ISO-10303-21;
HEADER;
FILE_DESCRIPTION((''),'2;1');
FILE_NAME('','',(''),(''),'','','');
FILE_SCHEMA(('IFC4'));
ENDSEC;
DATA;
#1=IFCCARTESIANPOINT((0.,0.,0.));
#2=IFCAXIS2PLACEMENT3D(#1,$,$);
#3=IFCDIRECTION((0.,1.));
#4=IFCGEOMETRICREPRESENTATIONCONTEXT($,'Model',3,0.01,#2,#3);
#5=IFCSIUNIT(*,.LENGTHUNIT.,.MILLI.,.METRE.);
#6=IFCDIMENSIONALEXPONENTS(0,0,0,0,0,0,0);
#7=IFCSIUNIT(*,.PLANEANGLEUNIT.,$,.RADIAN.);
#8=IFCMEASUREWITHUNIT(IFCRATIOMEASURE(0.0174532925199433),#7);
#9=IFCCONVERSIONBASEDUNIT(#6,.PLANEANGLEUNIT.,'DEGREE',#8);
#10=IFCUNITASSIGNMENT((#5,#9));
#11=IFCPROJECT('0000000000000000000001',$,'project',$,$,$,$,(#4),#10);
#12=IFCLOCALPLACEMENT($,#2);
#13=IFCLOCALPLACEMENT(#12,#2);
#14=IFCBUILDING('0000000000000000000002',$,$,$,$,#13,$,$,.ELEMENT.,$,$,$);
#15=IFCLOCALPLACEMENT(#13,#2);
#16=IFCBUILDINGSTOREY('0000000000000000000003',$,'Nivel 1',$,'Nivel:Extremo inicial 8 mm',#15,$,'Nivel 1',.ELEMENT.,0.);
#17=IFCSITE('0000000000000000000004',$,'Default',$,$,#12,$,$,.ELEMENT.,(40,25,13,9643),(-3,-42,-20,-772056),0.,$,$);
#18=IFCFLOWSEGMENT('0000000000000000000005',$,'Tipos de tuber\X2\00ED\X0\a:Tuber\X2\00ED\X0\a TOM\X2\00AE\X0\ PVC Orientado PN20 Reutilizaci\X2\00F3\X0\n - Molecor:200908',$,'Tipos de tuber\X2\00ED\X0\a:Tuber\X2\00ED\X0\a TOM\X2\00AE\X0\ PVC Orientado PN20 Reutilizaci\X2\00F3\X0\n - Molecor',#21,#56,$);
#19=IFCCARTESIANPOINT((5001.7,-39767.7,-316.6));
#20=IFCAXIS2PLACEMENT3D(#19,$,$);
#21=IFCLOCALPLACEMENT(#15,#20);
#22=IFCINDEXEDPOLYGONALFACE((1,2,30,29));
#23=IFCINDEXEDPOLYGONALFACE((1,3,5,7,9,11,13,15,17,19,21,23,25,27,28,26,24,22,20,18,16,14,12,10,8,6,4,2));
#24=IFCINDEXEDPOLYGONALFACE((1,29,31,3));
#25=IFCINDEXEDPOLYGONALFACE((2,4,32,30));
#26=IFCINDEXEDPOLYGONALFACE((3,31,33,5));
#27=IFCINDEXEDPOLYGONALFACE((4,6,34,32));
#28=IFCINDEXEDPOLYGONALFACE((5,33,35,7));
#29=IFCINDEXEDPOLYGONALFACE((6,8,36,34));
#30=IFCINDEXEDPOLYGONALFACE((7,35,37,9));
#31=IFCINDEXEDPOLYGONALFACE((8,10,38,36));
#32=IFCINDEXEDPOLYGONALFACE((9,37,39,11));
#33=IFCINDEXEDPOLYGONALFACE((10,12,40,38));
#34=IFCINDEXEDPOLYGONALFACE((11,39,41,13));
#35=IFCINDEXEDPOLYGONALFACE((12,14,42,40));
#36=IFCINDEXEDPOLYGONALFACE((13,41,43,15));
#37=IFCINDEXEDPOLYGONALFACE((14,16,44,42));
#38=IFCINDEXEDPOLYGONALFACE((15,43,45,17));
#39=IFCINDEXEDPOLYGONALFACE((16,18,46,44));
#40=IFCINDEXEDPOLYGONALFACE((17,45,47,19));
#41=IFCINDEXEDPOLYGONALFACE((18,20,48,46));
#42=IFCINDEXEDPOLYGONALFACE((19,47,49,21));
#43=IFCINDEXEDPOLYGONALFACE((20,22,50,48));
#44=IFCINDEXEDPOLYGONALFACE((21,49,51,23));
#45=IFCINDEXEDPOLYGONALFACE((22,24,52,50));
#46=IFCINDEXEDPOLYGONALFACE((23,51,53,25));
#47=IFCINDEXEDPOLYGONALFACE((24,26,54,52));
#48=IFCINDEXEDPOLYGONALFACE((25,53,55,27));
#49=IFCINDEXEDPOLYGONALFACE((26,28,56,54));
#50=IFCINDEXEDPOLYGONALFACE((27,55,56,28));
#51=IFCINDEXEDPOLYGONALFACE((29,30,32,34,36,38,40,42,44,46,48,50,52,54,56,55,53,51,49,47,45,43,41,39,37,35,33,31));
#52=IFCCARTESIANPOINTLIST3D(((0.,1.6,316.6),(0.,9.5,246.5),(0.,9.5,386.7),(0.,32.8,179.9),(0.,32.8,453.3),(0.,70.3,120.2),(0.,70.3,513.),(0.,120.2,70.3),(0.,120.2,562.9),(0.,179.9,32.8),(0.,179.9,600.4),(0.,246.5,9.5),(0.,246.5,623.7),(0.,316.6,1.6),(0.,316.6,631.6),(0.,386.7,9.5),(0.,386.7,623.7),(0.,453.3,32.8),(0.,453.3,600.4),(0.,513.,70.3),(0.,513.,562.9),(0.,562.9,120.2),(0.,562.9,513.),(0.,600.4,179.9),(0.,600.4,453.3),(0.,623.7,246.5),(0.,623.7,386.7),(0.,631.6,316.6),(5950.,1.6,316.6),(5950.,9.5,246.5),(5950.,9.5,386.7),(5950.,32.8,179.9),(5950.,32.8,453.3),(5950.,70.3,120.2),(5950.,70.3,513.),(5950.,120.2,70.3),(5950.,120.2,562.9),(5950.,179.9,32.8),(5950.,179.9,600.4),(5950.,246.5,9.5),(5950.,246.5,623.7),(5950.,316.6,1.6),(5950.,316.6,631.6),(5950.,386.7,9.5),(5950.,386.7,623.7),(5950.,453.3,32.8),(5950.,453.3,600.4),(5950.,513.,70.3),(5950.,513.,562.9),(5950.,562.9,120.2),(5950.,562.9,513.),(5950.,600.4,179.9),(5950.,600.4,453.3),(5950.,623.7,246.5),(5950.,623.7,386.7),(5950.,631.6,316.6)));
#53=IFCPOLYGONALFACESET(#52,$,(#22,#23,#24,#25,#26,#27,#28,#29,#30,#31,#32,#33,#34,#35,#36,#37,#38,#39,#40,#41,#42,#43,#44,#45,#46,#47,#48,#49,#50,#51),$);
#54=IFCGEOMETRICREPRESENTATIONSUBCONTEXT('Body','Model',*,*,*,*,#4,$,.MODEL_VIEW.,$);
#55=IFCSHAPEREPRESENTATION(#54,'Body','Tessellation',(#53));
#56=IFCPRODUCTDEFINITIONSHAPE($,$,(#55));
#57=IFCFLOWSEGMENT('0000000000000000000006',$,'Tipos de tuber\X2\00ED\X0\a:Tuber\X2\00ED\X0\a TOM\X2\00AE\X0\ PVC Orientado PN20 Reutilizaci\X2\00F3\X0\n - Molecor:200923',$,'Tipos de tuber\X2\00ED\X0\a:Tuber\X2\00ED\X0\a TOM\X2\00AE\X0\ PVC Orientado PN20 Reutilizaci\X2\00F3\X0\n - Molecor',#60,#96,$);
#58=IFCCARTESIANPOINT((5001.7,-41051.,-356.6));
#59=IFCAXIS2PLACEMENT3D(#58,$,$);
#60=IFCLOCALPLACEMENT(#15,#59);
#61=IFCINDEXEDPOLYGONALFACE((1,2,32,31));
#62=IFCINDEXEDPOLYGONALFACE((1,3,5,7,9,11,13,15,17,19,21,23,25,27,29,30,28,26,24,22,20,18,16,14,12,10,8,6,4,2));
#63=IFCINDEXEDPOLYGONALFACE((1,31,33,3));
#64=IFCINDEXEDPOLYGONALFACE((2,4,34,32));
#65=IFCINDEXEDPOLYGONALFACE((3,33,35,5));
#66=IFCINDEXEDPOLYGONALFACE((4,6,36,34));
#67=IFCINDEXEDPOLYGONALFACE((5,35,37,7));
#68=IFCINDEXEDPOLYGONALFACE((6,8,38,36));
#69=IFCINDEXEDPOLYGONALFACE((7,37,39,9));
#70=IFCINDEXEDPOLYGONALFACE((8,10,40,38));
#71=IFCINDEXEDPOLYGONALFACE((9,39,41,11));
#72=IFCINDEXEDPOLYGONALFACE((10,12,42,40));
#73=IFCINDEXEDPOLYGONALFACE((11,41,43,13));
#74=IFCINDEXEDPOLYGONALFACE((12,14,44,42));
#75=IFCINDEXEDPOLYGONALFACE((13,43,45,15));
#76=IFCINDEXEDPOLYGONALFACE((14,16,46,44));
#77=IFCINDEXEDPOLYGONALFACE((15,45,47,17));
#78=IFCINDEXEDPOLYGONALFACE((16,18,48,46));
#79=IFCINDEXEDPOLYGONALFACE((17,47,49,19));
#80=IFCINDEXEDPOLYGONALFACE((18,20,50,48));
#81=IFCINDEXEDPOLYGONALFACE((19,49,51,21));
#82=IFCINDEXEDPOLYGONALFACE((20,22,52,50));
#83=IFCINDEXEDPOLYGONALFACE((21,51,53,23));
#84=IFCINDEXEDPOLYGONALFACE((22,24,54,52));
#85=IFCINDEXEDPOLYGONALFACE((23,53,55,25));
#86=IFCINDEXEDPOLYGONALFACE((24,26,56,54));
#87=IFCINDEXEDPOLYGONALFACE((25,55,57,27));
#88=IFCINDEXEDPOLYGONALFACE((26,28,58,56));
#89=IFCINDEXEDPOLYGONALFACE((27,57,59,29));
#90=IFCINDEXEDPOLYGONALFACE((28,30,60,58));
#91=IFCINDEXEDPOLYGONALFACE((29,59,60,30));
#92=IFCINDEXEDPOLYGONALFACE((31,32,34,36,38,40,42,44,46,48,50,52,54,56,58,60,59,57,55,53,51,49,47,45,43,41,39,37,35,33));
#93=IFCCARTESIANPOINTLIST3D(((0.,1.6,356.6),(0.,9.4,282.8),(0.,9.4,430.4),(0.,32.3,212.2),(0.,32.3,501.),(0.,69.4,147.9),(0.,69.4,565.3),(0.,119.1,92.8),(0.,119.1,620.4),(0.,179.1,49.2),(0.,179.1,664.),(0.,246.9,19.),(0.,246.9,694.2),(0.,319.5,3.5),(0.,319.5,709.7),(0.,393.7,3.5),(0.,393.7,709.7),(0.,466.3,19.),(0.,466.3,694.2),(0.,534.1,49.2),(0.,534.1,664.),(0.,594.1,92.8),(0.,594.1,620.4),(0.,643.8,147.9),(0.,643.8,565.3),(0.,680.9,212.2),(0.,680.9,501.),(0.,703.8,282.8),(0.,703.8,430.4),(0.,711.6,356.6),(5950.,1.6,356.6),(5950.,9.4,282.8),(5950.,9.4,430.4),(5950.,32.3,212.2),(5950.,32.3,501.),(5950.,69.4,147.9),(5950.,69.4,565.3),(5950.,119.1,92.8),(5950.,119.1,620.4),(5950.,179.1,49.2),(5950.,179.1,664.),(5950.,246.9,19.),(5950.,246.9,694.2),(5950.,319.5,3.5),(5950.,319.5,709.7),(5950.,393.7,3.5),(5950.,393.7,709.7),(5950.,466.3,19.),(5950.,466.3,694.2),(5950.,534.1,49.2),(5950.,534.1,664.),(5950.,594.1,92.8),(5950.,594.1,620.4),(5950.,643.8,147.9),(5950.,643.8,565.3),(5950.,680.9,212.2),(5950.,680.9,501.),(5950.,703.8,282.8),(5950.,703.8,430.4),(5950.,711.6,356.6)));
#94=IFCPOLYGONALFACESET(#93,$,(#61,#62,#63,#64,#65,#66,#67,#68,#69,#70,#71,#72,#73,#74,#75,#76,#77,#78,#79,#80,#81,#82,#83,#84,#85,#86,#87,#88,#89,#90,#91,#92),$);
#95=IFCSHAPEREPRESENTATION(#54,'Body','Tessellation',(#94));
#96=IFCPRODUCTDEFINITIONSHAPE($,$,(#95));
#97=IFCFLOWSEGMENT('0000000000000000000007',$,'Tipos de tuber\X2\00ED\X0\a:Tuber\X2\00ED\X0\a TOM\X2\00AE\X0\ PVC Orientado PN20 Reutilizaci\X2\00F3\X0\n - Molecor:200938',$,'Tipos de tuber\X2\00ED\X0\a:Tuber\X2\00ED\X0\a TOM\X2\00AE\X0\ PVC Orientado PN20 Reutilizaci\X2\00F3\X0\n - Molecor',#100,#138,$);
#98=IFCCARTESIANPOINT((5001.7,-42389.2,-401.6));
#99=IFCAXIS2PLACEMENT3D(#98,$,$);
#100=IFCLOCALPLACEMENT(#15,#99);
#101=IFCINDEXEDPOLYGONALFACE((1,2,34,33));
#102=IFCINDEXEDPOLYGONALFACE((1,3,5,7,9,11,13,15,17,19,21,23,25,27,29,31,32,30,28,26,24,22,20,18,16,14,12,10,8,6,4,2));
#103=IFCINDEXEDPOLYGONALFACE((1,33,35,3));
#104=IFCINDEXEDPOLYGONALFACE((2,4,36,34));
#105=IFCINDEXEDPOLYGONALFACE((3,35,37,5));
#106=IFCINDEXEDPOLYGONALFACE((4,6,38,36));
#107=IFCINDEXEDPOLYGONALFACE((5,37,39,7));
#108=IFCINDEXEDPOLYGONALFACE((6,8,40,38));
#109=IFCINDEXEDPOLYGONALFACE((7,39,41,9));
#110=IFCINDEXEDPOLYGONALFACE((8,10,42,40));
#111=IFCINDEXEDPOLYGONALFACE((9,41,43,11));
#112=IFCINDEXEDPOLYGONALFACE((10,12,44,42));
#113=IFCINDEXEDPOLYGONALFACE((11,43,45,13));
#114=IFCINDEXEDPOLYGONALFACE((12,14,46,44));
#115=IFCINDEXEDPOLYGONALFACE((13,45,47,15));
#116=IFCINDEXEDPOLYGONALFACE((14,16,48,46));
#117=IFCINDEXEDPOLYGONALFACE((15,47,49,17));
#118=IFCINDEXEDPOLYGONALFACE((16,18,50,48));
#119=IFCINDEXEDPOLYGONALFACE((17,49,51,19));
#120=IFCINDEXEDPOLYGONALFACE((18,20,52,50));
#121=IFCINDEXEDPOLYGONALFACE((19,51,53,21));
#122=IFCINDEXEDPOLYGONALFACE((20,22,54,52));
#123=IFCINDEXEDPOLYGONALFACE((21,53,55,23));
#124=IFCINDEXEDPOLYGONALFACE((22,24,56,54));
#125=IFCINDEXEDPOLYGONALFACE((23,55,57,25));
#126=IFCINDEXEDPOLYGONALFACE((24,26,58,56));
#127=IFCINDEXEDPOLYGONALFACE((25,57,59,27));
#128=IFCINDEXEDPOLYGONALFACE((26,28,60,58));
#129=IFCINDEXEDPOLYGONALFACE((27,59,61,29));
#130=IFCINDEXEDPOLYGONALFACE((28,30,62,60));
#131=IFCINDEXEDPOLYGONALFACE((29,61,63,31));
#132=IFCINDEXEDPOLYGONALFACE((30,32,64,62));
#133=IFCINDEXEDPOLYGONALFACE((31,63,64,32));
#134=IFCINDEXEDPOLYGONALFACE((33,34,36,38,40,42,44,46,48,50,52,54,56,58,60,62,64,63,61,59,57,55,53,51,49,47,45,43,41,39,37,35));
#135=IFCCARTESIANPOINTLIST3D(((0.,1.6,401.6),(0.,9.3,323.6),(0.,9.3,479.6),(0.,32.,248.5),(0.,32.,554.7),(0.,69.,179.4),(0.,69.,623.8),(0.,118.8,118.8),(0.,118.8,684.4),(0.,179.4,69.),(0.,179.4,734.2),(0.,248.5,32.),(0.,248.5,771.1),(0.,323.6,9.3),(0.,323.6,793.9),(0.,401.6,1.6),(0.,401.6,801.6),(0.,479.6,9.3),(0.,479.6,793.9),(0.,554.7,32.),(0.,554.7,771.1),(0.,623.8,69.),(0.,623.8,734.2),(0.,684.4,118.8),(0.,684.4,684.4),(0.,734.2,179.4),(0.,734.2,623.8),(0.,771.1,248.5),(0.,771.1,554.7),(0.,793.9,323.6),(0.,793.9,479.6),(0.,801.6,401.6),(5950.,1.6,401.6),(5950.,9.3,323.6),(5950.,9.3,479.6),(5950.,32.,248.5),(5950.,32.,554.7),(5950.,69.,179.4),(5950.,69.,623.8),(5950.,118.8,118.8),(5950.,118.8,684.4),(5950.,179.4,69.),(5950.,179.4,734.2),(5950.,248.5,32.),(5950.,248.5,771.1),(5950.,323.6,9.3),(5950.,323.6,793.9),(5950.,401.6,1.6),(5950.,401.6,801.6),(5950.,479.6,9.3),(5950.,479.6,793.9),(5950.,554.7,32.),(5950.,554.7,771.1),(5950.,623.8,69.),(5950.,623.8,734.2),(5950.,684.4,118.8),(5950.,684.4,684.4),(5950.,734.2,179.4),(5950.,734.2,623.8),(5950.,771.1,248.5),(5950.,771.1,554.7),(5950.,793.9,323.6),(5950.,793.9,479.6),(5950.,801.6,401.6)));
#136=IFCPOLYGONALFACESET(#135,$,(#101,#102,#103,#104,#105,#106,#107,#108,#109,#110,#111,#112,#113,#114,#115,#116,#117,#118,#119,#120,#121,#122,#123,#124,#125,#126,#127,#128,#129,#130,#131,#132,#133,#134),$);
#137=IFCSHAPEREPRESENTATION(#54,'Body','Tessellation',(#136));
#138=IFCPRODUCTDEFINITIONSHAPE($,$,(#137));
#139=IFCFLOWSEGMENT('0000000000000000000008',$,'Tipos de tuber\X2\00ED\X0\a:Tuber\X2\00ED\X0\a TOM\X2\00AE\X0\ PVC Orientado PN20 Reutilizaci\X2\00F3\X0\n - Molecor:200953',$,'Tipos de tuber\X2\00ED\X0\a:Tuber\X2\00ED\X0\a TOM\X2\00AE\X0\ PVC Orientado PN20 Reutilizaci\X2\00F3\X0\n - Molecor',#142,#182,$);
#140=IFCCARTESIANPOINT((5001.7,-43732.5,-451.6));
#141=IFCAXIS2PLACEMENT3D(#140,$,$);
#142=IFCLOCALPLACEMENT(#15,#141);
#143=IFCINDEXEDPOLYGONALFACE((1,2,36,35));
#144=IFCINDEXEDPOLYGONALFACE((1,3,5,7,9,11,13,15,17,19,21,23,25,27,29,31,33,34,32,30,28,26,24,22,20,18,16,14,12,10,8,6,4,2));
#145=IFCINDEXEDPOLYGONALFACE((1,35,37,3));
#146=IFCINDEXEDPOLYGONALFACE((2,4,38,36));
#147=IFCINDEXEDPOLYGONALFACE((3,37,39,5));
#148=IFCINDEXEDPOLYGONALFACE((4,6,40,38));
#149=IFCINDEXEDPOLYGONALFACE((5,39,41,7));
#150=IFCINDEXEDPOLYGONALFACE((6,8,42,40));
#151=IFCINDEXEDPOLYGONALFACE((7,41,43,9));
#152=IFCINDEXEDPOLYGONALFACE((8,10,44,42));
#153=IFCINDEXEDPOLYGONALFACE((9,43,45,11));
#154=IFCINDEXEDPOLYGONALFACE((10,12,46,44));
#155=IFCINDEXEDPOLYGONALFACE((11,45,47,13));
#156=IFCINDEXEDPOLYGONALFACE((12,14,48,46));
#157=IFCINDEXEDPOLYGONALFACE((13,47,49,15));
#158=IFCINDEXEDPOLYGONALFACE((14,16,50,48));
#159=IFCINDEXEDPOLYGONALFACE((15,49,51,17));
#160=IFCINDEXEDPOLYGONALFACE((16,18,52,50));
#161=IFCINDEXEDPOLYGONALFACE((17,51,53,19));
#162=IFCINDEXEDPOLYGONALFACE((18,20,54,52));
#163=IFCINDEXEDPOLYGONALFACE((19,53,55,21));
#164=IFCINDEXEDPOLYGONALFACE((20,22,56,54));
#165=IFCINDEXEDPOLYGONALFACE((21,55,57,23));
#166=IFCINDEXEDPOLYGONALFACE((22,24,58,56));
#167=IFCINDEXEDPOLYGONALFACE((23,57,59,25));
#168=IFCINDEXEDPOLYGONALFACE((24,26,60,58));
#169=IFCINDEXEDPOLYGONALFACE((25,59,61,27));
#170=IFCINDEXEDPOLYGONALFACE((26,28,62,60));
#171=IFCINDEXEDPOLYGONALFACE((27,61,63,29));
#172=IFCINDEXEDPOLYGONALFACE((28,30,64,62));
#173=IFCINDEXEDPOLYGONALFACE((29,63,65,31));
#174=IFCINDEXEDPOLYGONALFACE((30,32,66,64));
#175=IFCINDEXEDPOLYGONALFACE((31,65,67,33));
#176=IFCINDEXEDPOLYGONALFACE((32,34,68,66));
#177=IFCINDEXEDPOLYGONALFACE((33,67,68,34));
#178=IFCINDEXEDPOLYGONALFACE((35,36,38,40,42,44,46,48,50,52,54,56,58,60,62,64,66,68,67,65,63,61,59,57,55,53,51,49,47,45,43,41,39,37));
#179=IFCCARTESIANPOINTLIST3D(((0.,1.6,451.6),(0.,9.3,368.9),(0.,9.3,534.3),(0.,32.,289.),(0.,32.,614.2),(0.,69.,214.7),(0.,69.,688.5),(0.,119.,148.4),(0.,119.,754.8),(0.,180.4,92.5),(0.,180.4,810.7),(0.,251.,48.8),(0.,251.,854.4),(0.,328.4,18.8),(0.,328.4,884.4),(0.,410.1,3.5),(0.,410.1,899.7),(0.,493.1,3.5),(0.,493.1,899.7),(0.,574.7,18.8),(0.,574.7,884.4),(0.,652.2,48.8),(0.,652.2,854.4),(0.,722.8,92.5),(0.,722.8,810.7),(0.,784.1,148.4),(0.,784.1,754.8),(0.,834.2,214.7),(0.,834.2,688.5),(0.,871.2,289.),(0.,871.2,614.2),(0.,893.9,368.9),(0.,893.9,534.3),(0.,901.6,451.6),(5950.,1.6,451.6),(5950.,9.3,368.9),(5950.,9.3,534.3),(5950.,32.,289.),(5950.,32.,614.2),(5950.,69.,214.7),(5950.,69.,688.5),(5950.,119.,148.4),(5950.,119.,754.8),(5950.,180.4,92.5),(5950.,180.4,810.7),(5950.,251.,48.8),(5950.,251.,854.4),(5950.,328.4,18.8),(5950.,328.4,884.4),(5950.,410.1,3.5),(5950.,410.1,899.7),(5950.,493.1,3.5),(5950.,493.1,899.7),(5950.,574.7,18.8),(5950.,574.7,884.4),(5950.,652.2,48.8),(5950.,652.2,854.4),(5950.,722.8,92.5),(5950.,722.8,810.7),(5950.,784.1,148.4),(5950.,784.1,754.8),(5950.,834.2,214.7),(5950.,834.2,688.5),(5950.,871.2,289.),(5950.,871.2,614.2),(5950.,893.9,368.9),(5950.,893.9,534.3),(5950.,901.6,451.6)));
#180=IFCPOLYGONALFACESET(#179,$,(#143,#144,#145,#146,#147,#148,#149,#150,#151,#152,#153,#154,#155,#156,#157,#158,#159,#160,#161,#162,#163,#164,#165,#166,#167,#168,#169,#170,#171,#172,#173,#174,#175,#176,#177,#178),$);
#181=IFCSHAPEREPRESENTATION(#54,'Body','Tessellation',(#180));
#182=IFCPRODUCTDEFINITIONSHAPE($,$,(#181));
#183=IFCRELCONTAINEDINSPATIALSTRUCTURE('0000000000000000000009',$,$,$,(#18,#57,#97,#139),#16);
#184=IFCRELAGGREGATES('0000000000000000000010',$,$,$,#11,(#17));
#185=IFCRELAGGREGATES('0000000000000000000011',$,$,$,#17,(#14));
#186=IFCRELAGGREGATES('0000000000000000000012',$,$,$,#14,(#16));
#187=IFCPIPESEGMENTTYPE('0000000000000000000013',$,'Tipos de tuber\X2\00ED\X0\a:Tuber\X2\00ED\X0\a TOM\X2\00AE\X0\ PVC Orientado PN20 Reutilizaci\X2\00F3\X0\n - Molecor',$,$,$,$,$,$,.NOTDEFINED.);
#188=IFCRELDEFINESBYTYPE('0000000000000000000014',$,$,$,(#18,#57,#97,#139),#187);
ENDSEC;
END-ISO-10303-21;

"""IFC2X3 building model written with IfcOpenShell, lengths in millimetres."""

from ifc_helpers import new_model, entity, si_unit, converted_unit, direction, frame, frame_2d, origin, place, context, subcontext, project, spatial, circle, extrude, type_object, element, save


model = new_model("IFC2X3")

# Units and contexts
model_context = context("Model", 3, precision=0.01, world=origin(), true_north=direction((0.0, 1.0)))
body_context = subcontext(model_context, "Body", "Model", "MODEL_VIEW")
ifc_project = project(units=[si_unit("LENGTHUNIT", "METRE", prefix="MILLI"), converted_unit("PLANEANGLEUNIT", "DEGREE", entity("IfcRatioMeasure", 0.0174532925199433), si_unit("PLANEANGLEUNIT", "RADIAN"), dimensions=[0, 0, 0, 0, 0, 0, 0])], contexts=[model_context])

# Site, building, storey
site_placement = place(None, origin())
site = spatial("IfcSite", under=ifc_project, at=site_placement, Name="Default", CompositionType="ELEMENT", RefLatitude=(40, 25, 13, 9643), RefLongitude=(-3, -42, -20, -772056), RefElevation=0.0)
building_placement = place(site_placement, origin())
building = spatial("IfcBuilding", under=site, at=building_placement, CompositionType="ELEMENT")
storey_placement = place(building_placement, origin())
storey = spatial("IfcBuildingStorey", under=building, at=storey_placement, Name="Nivel 1", ObjectType="Nivel:Extremo inicial 8 mm", LongName="Nivel 1", CompositionType="ELEMENT", Elevation=0.0)

# Flow segments
pipe_segment_type_1 = type_object("IfcPipeSegmentType", Name="Tipos de tubería:Tubería TOM® PVC Orientado PN20 Reutilización - Molecor", PredefinedType="NOTDEFINED")
flow_segment_1_placement = place(storey_placement, frame((5001.7, -39767.7, -316.6)))
element("IfcFlowSegment", 1, at=flow_segment_1_placement, inside=storey, type_object=pipe_segment_type_1, Name="Tipos de tubería:Tubería TOM® PVC Orientado PN20 Reutilización - Molecor:200908", ObjectType="Tipos de tubería:Tubería TOM® PVC Orientado PN20 Reutilización - Molecor", context=body_context, shape_type="SweptSolid", body=[
    extrude(circle(Radius=315.0, at=frame_2d((0.0, 0.0), x_axis=(1.0, 0.0))), frame((0.0, 316.6, 316.6), z_axis=(1.0, 0.0, 0.0), x_axis=(0.0, 1.0, 0.0)), (0.0, 0.0, 1.0), 5950.0),
])
flow_segment_2_placement = place(storey_placement, frame((5001.7, -41051.0, -356.6)))
element("IfcFlowSegment", 2, at=flow_segment_2_placement, inside=storey, type_object=pipe_segment_type_1, Name="Tipos de tubería:Tubería TOM® PVC Orientado PN20 Reutilización - Molecor:200923", ObjectType="Tipos de tubería:Tubería TOM® PVC Orientado PN20 Reutilización - Molecor", context=body_context, shape_type="SweptSolid", body=[
    extrude(circle(Radius=355.0, at=frame_2d((0.0, 0.0), x_axis=(1.0, 0.0))), frame((0.0, 356.6, 356.6), z_axis=(1.0, 0.0, 0.0), x_axis=(0.0, 1.0, 0.0)), (0.0, 0.0, 1.0), 5950.0),
])
flow_segment_3_placement = place(storey_placement, frame((5001.7, -42389.2, -401.6)))
element("IfcFlowSegment", 3, at=flow_segment_3_placement, inside=storey, type_object=pipe_segment_type_1, Name="Tipos de tubería:Tubería TOM® PVC Orientado PN20 Reutilización - Molecor:200938", ObjectType="Tipos de tubería:Tubería TOM® PVC Orientado PN20 Reutilización - Molecor", context=body_context, shape_type="SweptSolid", body=[
    extrude(circle(Radius=400.0, at=frame_2d((0.0, 0.0), x_axis=(1.0, 0.0))), frame((0.0, 401.6, 401.6), z_axis=(1.0, 0.0, 0.0), x_axis=(0.0, 1.0, 0.0)), (0.0, 0.0, 1.0), 5950.0),
])
flow_segment_4_placement = place(storey_placement, frame((5001.7, -43732.5, -451.6)))
element("IfcFlowSegment", 4, at=flow_segment_4_placement, inside=storey, type_object=pipe_segment_type_1, Name="Tipos de tubería:Tubería TOM® PVC Orientado PN20 Reutilización - Molecor:200953", ObjectType="Tipos de tubería:Tubería TOM® PVC Orientado PN20 Reutilización - Molecor", context=body_context, shape_type="SweptSolid", body=[
    extrude(circle(Radius=450.0, at=frame_2d((0.0, 0.0), x_axis=(1.0, 0.0))), frame((0.0, 451.6, 451.6), z_axis=(1.0, 0.0, 0.0), x_axis=(0.0, 1.0, 0.0)), (0.0, 0.0, 1.0), 5950.0),
])

save(model, "model.ifc")
